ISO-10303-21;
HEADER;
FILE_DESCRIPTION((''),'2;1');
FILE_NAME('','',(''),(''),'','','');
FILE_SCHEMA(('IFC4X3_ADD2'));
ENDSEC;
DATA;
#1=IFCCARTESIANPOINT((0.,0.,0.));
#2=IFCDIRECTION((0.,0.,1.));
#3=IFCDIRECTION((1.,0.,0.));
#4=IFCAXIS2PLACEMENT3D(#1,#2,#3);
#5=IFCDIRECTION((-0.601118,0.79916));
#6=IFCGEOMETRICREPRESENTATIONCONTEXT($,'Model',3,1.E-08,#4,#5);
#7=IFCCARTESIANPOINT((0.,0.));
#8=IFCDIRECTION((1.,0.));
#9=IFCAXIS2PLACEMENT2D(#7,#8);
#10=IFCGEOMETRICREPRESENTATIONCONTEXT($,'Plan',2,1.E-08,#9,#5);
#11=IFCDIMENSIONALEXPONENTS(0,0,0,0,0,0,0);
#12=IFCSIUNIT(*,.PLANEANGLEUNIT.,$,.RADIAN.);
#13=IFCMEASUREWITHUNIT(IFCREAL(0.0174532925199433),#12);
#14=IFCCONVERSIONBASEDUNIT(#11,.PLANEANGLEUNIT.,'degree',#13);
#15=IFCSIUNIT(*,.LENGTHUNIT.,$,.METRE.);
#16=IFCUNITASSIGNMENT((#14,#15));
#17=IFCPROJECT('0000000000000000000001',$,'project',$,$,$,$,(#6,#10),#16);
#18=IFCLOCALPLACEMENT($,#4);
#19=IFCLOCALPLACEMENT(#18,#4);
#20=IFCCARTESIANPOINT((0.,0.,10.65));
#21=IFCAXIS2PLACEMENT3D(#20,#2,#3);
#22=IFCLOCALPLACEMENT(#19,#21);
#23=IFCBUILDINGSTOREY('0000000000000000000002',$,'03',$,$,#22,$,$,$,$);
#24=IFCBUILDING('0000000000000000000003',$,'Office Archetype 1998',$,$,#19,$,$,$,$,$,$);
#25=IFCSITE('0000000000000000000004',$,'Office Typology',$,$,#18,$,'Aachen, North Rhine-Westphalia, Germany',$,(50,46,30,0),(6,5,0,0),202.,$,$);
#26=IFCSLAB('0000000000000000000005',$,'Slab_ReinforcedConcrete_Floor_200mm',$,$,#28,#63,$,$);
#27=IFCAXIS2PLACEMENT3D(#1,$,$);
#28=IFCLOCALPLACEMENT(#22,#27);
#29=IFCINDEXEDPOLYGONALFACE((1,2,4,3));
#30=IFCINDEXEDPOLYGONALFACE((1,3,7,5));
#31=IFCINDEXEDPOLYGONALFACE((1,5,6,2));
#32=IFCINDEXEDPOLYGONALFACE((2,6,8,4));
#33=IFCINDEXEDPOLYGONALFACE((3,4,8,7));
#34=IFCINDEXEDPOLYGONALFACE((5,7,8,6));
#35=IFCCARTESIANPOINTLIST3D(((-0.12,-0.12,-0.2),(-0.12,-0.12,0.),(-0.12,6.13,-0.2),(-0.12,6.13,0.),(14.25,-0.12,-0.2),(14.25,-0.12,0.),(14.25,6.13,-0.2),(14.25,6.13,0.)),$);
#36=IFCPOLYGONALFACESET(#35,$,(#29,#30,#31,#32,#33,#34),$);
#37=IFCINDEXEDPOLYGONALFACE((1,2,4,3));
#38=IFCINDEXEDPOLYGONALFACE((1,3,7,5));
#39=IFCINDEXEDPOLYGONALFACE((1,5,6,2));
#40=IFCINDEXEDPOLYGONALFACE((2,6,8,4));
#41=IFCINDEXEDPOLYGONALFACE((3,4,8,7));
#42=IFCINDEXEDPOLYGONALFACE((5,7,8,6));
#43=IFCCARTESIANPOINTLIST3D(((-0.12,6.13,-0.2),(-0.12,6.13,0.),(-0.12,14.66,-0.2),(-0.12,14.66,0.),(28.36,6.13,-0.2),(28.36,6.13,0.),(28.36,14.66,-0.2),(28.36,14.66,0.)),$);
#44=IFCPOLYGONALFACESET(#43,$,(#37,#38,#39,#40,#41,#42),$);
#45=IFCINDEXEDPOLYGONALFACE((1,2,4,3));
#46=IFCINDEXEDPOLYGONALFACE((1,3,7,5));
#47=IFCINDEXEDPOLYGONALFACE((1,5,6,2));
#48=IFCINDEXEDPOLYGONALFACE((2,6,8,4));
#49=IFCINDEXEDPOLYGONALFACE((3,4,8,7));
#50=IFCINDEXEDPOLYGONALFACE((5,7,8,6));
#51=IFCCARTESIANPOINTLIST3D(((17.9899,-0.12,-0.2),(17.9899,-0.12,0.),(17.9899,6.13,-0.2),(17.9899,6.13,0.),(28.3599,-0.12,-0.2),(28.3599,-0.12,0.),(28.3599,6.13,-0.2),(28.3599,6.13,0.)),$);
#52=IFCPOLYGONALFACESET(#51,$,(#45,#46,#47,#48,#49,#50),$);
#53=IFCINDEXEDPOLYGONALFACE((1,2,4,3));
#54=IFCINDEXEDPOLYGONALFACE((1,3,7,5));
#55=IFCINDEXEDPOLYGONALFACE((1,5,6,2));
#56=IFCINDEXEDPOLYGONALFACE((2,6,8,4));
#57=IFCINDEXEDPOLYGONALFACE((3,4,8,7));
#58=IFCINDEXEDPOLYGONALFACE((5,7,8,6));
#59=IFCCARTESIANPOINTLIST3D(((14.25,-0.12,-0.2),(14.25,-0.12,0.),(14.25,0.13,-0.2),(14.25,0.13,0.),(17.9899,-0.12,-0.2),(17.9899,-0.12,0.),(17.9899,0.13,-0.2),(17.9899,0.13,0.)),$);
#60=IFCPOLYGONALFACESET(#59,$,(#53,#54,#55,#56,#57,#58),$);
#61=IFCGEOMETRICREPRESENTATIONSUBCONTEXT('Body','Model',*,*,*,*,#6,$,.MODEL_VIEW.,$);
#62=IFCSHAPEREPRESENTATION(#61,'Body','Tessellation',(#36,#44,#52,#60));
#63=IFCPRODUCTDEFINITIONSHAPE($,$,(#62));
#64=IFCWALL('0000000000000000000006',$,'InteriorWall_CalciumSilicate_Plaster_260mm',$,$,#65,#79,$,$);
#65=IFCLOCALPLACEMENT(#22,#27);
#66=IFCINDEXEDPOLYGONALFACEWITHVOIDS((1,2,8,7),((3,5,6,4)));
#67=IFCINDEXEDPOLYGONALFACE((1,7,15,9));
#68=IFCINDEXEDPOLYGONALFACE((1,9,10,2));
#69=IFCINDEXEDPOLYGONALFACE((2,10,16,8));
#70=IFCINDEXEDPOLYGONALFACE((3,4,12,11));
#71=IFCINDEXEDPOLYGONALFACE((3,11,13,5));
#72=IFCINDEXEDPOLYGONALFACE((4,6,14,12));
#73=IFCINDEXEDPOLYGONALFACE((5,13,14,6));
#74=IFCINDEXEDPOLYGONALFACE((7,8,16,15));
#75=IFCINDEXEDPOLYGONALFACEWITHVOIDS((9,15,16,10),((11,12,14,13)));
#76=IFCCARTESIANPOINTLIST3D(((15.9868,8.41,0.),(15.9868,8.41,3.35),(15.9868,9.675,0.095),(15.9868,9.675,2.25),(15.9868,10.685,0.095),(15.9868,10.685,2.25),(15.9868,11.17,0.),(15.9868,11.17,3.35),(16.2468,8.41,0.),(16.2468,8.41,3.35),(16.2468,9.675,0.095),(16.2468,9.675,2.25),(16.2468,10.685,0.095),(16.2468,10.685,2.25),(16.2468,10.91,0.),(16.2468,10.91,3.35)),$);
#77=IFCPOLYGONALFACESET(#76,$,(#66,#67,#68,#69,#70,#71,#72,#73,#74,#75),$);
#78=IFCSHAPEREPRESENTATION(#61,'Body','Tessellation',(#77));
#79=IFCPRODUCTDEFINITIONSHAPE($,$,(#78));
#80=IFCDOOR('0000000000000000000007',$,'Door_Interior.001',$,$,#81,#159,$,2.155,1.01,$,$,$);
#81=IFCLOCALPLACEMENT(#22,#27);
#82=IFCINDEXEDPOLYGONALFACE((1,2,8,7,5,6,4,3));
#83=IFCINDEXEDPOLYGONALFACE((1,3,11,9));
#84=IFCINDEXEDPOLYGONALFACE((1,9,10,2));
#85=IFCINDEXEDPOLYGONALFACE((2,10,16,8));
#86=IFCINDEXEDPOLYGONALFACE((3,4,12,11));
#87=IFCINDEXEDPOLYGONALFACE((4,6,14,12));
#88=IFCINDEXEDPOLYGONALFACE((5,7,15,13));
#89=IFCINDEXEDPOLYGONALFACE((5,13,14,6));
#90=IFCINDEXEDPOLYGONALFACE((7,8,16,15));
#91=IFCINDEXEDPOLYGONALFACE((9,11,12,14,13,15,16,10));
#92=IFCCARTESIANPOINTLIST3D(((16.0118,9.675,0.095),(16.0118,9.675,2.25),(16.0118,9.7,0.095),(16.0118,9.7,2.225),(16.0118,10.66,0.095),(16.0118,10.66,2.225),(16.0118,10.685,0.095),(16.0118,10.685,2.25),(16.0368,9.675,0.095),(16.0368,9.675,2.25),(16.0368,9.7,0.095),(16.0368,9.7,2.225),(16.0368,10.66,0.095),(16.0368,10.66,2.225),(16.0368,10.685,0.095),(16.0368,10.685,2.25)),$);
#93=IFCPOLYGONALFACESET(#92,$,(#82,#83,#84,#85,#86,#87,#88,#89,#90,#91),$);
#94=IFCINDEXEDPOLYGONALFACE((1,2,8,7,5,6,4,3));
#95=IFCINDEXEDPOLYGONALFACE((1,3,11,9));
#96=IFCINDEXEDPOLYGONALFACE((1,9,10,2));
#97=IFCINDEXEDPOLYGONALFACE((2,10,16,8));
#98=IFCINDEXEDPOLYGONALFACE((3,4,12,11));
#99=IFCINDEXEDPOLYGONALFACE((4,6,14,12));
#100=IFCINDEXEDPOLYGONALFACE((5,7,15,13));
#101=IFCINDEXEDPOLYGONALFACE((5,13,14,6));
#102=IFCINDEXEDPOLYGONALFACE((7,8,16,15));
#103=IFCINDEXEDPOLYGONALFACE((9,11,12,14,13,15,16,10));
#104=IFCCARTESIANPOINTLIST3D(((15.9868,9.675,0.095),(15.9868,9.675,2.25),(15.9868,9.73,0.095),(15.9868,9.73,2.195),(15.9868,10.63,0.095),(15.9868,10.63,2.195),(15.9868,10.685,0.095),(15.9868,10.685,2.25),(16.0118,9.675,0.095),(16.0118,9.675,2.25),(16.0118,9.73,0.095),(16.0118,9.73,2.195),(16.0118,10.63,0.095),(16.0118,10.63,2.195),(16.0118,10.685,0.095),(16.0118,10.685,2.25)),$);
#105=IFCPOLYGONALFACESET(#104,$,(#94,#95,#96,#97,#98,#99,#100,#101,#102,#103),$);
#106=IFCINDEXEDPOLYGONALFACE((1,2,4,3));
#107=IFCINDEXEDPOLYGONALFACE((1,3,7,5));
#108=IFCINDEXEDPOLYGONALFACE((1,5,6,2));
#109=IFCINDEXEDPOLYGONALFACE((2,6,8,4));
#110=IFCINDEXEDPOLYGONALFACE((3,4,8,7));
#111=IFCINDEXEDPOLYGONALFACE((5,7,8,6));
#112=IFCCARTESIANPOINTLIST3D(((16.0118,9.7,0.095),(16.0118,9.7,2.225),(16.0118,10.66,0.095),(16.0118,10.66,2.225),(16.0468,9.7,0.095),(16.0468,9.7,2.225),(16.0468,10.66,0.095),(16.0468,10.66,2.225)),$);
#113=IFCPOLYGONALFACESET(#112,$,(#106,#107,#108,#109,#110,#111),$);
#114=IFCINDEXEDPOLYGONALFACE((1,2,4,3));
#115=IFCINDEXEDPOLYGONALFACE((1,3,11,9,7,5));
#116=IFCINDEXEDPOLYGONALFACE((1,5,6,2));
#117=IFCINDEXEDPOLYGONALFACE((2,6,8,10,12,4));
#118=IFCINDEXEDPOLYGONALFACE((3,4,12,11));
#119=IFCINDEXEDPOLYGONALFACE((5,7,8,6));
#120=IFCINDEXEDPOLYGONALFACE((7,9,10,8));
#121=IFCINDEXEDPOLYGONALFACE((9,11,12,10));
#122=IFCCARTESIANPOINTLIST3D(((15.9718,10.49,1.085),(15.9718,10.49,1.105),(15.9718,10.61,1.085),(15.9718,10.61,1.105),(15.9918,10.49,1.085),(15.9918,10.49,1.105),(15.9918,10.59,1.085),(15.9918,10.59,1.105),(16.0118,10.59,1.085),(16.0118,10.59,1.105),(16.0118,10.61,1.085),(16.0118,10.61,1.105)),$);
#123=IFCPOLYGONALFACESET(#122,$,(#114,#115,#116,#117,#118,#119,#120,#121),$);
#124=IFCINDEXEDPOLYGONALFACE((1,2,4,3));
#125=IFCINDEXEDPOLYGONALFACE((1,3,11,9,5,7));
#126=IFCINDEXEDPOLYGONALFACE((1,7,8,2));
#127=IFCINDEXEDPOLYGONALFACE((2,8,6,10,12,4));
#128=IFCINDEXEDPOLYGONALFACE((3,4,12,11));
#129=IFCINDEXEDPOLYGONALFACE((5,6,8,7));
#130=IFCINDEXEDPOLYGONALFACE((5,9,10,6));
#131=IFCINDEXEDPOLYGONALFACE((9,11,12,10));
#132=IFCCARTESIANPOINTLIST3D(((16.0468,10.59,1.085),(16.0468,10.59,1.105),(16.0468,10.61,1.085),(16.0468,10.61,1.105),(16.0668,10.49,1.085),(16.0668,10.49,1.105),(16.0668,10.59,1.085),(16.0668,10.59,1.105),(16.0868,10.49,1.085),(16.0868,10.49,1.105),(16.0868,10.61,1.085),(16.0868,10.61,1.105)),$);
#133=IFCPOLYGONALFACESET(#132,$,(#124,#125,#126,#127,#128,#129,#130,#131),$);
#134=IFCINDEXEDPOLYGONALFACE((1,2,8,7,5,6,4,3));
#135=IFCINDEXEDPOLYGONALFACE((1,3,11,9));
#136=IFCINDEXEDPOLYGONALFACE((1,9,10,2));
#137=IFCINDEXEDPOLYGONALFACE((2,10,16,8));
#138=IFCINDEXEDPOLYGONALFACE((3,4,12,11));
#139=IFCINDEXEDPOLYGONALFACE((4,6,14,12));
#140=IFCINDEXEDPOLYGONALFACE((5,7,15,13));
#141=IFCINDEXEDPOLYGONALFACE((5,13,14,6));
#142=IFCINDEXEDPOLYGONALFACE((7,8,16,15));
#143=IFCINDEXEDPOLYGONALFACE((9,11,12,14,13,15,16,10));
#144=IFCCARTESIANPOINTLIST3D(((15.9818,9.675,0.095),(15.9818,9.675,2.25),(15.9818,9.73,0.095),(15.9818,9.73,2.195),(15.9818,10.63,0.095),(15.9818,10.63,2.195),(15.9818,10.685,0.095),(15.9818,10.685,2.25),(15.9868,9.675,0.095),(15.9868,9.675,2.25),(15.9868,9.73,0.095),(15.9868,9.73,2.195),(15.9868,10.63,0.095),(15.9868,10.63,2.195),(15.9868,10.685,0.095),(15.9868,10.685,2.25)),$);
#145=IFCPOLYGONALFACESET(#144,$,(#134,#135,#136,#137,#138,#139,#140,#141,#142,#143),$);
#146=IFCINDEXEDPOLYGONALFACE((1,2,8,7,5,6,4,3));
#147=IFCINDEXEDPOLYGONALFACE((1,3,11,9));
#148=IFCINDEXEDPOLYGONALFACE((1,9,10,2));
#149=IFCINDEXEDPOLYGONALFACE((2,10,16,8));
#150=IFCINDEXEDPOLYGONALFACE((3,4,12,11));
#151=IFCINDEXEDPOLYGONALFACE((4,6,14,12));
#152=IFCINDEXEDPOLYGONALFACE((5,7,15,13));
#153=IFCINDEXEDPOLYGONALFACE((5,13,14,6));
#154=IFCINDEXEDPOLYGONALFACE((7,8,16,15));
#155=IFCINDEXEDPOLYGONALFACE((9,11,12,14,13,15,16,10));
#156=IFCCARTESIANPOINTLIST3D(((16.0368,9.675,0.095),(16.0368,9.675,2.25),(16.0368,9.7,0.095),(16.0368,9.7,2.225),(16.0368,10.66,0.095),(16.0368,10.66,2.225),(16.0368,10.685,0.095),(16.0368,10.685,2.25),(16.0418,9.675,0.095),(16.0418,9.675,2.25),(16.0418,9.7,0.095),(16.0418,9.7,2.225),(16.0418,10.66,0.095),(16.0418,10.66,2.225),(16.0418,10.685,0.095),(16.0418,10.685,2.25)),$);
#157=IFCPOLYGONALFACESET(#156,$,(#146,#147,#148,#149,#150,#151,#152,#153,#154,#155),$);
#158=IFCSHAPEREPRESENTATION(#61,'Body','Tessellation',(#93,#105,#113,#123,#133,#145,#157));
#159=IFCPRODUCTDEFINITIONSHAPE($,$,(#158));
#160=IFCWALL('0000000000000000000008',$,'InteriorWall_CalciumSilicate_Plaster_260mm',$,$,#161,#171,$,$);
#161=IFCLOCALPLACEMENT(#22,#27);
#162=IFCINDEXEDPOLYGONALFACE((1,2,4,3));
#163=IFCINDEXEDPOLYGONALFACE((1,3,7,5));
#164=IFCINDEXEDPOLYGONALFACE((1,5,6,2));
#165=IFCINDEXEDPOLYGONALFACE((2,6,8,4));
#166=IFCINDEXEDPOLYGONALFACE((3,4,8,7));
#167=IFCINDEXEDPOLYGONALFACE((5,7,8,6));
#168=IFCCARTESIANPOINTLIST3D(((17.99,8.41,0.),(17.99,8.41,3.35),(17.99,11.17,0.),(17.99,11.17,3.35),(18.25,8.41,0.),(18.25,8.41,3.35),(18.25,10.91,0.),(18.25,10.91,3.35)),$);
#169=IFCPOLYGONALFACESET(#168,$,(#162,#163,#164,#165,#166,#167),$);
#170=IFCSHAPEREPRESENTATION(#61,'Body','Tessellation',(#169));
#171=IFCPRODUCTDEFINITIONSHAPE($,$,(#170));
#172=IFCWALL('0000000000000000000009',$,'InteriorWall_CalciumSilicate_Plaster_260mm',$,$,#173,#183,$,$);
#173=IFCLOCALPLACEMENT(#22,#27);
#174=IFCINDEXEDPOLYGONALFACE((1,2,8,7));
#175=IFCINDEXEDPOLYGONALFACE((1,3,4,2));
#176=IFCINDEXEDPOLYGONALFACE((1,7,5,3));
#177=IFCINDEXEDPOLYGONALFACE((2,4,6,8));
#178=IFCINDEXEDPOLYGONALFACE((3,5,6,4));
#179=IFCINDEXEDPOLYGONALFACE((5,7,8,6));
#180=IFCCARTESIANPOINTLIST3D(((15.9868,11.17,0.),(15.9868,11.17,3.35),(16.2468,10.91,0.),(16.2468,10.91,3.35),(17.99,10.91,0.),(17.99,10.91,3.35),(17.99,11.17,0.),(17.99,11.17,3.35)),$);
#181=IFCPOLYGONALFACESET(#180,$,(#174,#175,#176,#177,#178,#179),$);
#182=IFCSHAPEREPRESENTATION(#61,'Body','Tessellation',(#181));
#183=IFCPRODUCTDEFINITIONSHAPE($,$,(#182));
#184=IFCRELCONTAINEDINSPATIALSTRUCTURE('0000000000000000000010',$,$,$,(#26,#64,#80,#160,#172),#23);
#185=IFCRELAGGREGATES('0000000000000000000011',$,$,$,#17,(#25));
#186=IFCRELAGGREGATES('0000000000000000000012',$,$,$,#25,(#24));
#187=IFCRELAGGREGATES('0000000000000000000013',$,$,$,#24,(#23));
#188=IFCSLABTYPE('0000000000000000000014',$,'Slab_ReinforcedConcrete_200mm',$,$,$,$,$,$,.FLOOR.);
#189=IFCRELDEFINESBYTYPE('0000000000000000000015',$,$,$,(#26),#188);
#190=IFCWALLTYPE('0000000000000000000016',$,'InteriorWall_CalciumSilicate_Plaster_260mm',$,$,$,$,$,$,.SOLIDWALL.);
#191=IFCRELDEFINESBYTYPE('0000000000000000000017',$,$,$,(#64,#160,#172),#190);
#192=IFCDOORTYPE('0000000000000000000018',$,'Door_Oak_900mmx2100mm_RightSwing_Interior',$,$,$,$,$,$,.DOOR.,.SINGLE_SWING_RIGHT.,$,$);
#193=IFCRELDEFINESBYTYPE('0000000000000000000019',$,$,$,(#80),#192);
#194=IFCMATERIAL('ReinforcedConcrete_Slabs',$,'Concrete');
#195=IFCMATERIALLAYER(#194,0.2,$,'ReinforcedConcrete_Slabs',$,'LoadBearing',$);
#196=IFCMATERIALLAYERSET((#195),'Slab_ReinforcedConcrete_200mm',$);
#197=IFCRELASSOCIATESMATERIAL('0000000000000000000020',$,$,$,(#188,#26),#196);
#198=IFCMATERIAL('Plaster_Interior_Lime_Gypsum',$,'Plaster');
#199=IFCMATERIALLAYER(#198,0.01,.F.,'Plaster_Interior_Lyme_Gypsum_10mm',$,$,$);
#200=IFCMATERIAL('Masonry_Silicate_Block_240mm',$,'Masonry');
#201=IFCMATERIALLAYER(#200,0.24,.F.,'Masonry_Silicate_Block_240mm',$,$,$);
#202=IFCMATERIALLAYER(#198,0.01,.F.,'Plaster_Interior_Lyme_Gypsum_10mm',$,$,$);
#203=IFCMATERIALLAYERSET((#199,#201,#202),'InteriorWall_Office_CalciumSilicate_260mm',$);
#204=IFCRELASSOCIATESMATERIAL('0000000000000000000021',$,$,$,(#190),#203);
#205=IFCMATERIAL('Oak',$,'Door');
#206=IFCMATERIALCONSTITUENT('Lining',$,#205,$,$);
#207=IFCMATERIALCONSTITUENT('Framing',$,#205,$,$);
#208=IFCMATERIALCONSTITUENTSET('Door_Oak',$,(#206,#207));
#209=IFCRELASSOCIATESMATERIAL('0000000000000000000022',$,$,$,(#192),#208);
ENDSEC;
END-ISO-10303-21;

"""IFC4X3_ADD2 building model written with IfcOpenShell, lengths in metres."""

from ifc_helpers import new_model, entity, si_unit, converted_unit, direction, frame, origin_with_axes, origin_2d_with_axis, place, context, subcontext, project, spatial, line, indexed_curve, outline, extrude, source, transform, mapped, material, layer, layer_set, layer_usage, constituent, constituent_set, type_object, type_shapes, element, fill, save


model = new_model("IFC4X3_ADD2")

# Units and contexts
model_context = context("Model", 3, precision=1e-08, world=origin_with_axes(), true_north=direction((-0.601118, 0.79916)))
plan_context = context("Plan", 2, precision=1e-08, world=origin_2d_with_axis(), true_north=direction((-0.601118, 0.79916)))
body_context = subcontext(model_context, "Body", "Model", "MODEL_VIEW")
ifc_project = project(units=[converted_unit("PLANEANGLEUNIT", "degree", entity("IfcReal", 0.0174532925199433), si_unit("PLANEANGLEUNIT", "RADIAN"), dimensions=[0, 0, 0, 0, 0, 0, 0]), si_unit("LENGTHUNIT", "METRE")], contexts=[model_context, plan_context])

# Site, building, storey
site_placement = place(None, origin_with_axes())
site = spatial("IfcSite", under=ifc_project, at=site_placement, Name="Office Typology", LongName="Aachen, North Rhine-Westphalia, Germany", RefLatitude=(50, 46, 30, 0), RefLongitude=(6, 5, 0, 0), RefElevation=202.0)
building_placement = place(site_placement, origin_with_axes())
building = spatial("IfcBuilding", under=site, at=building_placement, Name="Office Archetype 1998")
storey_placement = place(building_placement, frame((0.0, 0.0, 10.65), z_axis=(0.0, 0.0, 1.0), x_axis=(1.0, 0.0, 0.0)))
storey = spatial("IfcBuildingStorey", under=building, at=storey_placement, Name="03")

# Slab
ifc_material_1 = material(Name="ReinforcedConcrete_Slabs", Category="Concrete")
ifc_layer_1 = layer(ifc_material_1, 0.2, Name="ReinforcedConcrete_Slabs", Category="LoadBearing")
ifc_layer_set_1 = layer_set([ifc_layer_1], Name="Slab_ReinforcedConcrete_200mm")
slab_type = type_object("IfcSlabType", Name="Slab_ReinforcedConcrete_200mm", PredefinedType="FLOOR", material=ifc_layer_set_1)
ifc_layer_usage_1 = layer_usage(ifc_layer_set_1, "AXIS3", "POSITIVE", 0.0)
slab_1_placement = place(storey_placement, frame((17.9899, 6.13, 0.0), z_axis=(0.0, 0.0, 1.0), x_axis=(1.0, 0.0, 0.0)))
element("IfcSlab", 1, at=slab_1_placement, inside=storey, type_object=slab_type, material=ifc_layer_usage_1, Name="Slab_ReinforcedConcrete_Floor_200mm", context=body_context, shape_type="SweptSolid", body=[
    extrude(outline(indexed_curve([(0.0, -6.25), (14.37, -6.25), (14.37, 0.0), (0.0, 0.0), (0.0, -6.25)])), frame((-18.1099, 0.0, -0.2), z_axis=(0.0, 0.0, 1.0), x_axis=(1.0, 0.0, 0.0)), (0.0, 0.0, 1.0), 0.2),
    extrude(outline(indexed_curve([(0.0, 0.0), (28.48, 0.0), (28.48, -8.53), (0.0, -8.53), (0.0, 0.0)])), frame((-18.1099, 8.53, -0.2), z_axis=(0.0, 0.0, 1.0), x_axis=(1.0, 0.0, 0.0)), (0.0, 0.0, 1.0), 0.2),
    extrude(outline(indexed_curve([(0.0, 0.0), (0.0, -6.25), (10.37, -6.25), (10.37, 0.0), (0.0, 0.0)])), frame((0.0, 0.0, -0.2), z_axis=(0.0, 0.0, 1.0), x_axis=(1.0, 0.0, 0.0)), (0.0, 0.0, 1.0), 0.2),
    extrude(outline(indexed_curve([(0.0, 0.0), (3.7399, 0.0), (3.7399, 0.25), (0.0, 0.25), (0.0, 0.0)])), frame((-3.7399, -6.25, -0.2), z_axis=(0.0, 0.0, 1.0), x_axis=(1.0, 0.0, 0.0)), (0.0, 0.0, 1.0), 0.2),
])

# Wall, opening, door
ifc_material_2 = material(Name="Plaster_Interior_Lime_Gypsum", Category="Plaster")
ifc_layer_2 = layer(ifc_material_2, 0.01, ventilated=False, Name="Plaster_Interior_Lyme_Gypsum_10mm")
ifc_material_3 = material(Name="Masonry_Silicate_Block_240mm", Category="Masonry")
ifc_layer_3 = layer(ifc_material_3, 0.24, ventilated=False, Name="Masonry_Silicate_Block_240mm")
ifc_layer_4 = layer(ifc_material_2, 0.01, ventilated=False, Name="Plaster_Interior_Lyme_Gypsum_10mm")
ifc_layer_set_2 = layer_set([ifc_layer_2, ifc_layer_3, ifc_layer_4], Name="InteriorWall_Office_CalciumSilicate_260mm")
wall_type_1 = type_object("IfcWallType", Name="InteriorWall_CalciumSilicate_Plaster_260mm", PredefinedType="SOLIDWALL", material=ifc_layer_set_2)
wall_1_placement = place(storey_placement, frame((15.9868, 11.17, 0.0), z_axis=(0.0, 0.0, 1.0), x_axis=(0.0, -1.0, 0.0)))
wall_1 = element("IfcWall", 2, at=wall_1_placement, inside=storey, type_object=wall_type_1, Name="InteriorWall_CalciumSilicate_Plaster_260mm", context=body_context, shape_type="SweptSolid", body=[
    extrude(outline(indexed_curve([(0.0, 0.0), (0.26, 0.26), (2.76, 0.26), (2.76, 0.0)], segments=[line(1, 2, 3, 4, 1)])), origin_with_axes(), (0.0, 0.0, 1.0), 3.35),
])
shared_shape_1 = source(origin_with_axes(), body_context, "Body", "SweptSolid", [
    extrude(outline(indexed_curve([(0.0, 2.155), (1.01, 2.155), (1.01, 0.0), (0.0, 0.0), (0.0, 2.155)])), frame((0.0, 0.0, 0.0), z_axis=(0.0, -1.0, 0.0), x_axis=(1.0, 0.0, 0.0)), (0.0, 0.0, -1.0), 0.26),
])
opening_1_placement = place(wall_1_placement, frame((0.485, 0.0, 0.095), z_axis=(0.0, 0.0, 1.0), x_axis=(1.0, 0.0, 0.0)))
opening_1 = element("IfcOpeningElement", 3, at=opening_1_placement, cuts=wall_1, PredefinedType="OPENING", context=body_context, shape_type="MappedRepresentation", body=[
    mapped(shared_shape_1, transform((0.0, 0.0, 0.0), x_axis=(1.0, 0.0, 0.0), y_axis=(0.0, 1.0, 0.0), z_axis=(0.0, 0.0, 1.0), scale=1.0)),
])
ifc_material_4 = material(Name="Oak", Category="Door")
ifc_constituent_1 = constituent(ifc_material_4, Name="Lining")
ifc_constituent_2 = constituent(ifc_material_4, Name="Framing")
ifc_constituent_set_1 = constituent_set(constituents=[ifc_constituent_1, ifc_constituent_2], Name="Door_Oak")
door_type_1 = type_object("IfcDoorType", Name="Door_Oak_900mmx2100mm_RightSwing_Interior", OperationType="SINGLE_SWING_RIGHT", PredefinedType="DOOR", material=ifc_constituent_set_1)
shared_shape_2 = source(origin_with_axes(), body_context, "Body", "SweptSolid", [
    extrude(outline(indexed_curve([(0.0, 0.0), (0.0, 2.155), (1.01, 2.155), (1.01, 0.0), (0.985, 0.0), (0.985, 2.13), (0.025, 2.13), (0.025, 0.0)], segments=[line(1, 2, 3, 4, 5, 6, 7, 8, 1)])), frame((0.0, 0.025, 0.0), z_axis=(0.0, -1.0, 0.0), x_axis=(1.0, 0.0, 0.0)), (0.0, 0.0, -1.0), 0.025),
    extrude(outline(indexed_curve([(0.0, 0.0), (0.0, 2.155), (1.01, 2.155), (1.01, 0.0), (0.955, 0.0), (0.955, 2.1), (0.055, 2.1), (0.055, 0.0)], segments=[line(1, 2, 3, 4, 5, 6, 7, 8, 1)])), frame((0.0, 0.0, 0.0), z_axis=(0.0, -1.0, 0.0), x_axis=(1.0, 0.0, 0.0)), (0.0, 0.0, -1.0), 0.025),
    extrude(outline(indexed_curve([(0.0, 0.0), (0.96, 0.0), (0.96, 0.035), (0.0, 0.035)], segments=[line(1, 2, 3, 4, 1)])), frame((0.025, 0.025, 0.0), z_axis=(0.0, 0.0, 1.0), x_axis=(1.0, 0.0, 0.0)), (0.0, 0.0, 1.0), 2.13),
    extrude(outline(indexed_curve([(0.0, 0.0), (0.0, -0.04), (0.12, -0.04), (0.12, -0.02), (0.02, -0.02), (0.02, 0.0)], segments=[line(1, 2, 3, 4, 5, 6, 1)])), frame((0.075, 0.025, 0.99), z_axis=(0.0, 0.0, 1.0), x_axis=(1.0, 0.0, 0.0)), (0.0, 0.0, 1.0), 0.02),
    extrude(outline(indexed_curve([(0.0, 0.0), (0.0, 0.04), (0.12, 0.04), (0.12, 0.02), (0.02, 0.02), (0.02, 0.0)], segments=[line(1, 2, 3, 4, 5, 6, 1)])), frame((0.075, 0.06, 0.99), z_axis=(0.0, 0.0, 1.0), x_axis=(1.0, 0.0, 0.0)), (0.0, 0.0, 1.0), 0.02),
    extrude(outline(indexed_curve([(0.0, 0.0), (0.0, 2.155), (1.01, 2.155), (1.01, 0.0), (0.955, 0.0), (0.955, 2.1), (0.055, 2.1), (0.055, 0.0)], segments=[line(1, 2, 3, 4, 5, 6, 7, 8, 1)])), frame((0.0, -0.005, 0.0), z_axis=(0.0, -1.0, 0.0), x_axis=(1.0, 0.0, 0.0)), (0.0, 0.0, -1.0), 0.005),
    extrude(outline(indexed_curve([(0.0, 0.0), (0.0, 2.155), (1.01, 2.155), (1.01, 0.0), (0.985, 0.0), (0.985, 2.13), (0.025, 2.13), (0.025, 0.0)], segments=[line(1, 2, 3, 4, 5, 6, 7, 8, 1)])), frame((0.0, 0.05, 0.0), z_axis=(0.0, -1.0, 0.0), x_axis=(1.0, 0.0, 0.0)), (0.0, 0.0, -1.0), 0.005),
])
type_shapes(door_type_1, [shared_shape_2])
door_1_placement = place(opening_1_placement, origin_with_axes())
door_1 = element("IfcDoor", 4, at=door_1_placement, inside=storey, type_object=door_type_1, Name="Door_Interior.001", OverallHeight=2.155, OverallWidth=1.01, context=body_context, shape_type="MappedRepresentation", body=[
    mapped(shared_shape_2, transform((0.0, 0.0, 0.0), x_axis=(1.0, 0.0, 0.0), y_axis=(0.0, 1.0, 0.0), z_axis=(0.0, 0.0, 1.0), scale=1.0)),
])
fill(opening_1, door_1)

# Walls
wall_2_placement = place(storey_placement, frame((17.99, 11.17, 0.0), z_axis=(0.0, 0.0, 1.0), x_axis=(0.0, -1.0, 0.0)))
element("IfcWall", 5, at=wall_2_placement, inside=storey, type_object=wall_type_1, Name="InteriorWall_CalciumSilicate_Plaster_260mm", context=body_context, shape_type="SweptSolid", body=[
    extrude(outline(indexed_curve([(0.0, 0.0), (0.26, 0.26), (2.76, 0.26), (2.76, 0.0)], segments=[line(1, 2, 3, 4, 1)])), origin_with_axes(), (0.0, 0.0, 1.0), 3.35),
])
wall_3_placement = place(storey_placement, frame((17.99, 11.17, 0.0), z_axis=(0.0, 0.0, 1.0), x_axis=(-1.0, 0.0, 0.0)))
element("IfcWall", 6, at=wall_3_placement, inside=storey, type_object=wall_type_1, Name="InteriorWall_CalciumSilicate_Plaster_260mm", context=body_context, shape_type="SweptSolid", body=[
    extrude(outline(indexed_curve([(0.0, 0.0), (0.0, 0.26), (1.7432, 0.26), (2.0032, 0.0)], segments=[line(1, 2, 3, 4, 1)])), origin_with_axes(), (0.0, 0.0, 1.0), 3.35),
])

save(model, "model.ifc")
